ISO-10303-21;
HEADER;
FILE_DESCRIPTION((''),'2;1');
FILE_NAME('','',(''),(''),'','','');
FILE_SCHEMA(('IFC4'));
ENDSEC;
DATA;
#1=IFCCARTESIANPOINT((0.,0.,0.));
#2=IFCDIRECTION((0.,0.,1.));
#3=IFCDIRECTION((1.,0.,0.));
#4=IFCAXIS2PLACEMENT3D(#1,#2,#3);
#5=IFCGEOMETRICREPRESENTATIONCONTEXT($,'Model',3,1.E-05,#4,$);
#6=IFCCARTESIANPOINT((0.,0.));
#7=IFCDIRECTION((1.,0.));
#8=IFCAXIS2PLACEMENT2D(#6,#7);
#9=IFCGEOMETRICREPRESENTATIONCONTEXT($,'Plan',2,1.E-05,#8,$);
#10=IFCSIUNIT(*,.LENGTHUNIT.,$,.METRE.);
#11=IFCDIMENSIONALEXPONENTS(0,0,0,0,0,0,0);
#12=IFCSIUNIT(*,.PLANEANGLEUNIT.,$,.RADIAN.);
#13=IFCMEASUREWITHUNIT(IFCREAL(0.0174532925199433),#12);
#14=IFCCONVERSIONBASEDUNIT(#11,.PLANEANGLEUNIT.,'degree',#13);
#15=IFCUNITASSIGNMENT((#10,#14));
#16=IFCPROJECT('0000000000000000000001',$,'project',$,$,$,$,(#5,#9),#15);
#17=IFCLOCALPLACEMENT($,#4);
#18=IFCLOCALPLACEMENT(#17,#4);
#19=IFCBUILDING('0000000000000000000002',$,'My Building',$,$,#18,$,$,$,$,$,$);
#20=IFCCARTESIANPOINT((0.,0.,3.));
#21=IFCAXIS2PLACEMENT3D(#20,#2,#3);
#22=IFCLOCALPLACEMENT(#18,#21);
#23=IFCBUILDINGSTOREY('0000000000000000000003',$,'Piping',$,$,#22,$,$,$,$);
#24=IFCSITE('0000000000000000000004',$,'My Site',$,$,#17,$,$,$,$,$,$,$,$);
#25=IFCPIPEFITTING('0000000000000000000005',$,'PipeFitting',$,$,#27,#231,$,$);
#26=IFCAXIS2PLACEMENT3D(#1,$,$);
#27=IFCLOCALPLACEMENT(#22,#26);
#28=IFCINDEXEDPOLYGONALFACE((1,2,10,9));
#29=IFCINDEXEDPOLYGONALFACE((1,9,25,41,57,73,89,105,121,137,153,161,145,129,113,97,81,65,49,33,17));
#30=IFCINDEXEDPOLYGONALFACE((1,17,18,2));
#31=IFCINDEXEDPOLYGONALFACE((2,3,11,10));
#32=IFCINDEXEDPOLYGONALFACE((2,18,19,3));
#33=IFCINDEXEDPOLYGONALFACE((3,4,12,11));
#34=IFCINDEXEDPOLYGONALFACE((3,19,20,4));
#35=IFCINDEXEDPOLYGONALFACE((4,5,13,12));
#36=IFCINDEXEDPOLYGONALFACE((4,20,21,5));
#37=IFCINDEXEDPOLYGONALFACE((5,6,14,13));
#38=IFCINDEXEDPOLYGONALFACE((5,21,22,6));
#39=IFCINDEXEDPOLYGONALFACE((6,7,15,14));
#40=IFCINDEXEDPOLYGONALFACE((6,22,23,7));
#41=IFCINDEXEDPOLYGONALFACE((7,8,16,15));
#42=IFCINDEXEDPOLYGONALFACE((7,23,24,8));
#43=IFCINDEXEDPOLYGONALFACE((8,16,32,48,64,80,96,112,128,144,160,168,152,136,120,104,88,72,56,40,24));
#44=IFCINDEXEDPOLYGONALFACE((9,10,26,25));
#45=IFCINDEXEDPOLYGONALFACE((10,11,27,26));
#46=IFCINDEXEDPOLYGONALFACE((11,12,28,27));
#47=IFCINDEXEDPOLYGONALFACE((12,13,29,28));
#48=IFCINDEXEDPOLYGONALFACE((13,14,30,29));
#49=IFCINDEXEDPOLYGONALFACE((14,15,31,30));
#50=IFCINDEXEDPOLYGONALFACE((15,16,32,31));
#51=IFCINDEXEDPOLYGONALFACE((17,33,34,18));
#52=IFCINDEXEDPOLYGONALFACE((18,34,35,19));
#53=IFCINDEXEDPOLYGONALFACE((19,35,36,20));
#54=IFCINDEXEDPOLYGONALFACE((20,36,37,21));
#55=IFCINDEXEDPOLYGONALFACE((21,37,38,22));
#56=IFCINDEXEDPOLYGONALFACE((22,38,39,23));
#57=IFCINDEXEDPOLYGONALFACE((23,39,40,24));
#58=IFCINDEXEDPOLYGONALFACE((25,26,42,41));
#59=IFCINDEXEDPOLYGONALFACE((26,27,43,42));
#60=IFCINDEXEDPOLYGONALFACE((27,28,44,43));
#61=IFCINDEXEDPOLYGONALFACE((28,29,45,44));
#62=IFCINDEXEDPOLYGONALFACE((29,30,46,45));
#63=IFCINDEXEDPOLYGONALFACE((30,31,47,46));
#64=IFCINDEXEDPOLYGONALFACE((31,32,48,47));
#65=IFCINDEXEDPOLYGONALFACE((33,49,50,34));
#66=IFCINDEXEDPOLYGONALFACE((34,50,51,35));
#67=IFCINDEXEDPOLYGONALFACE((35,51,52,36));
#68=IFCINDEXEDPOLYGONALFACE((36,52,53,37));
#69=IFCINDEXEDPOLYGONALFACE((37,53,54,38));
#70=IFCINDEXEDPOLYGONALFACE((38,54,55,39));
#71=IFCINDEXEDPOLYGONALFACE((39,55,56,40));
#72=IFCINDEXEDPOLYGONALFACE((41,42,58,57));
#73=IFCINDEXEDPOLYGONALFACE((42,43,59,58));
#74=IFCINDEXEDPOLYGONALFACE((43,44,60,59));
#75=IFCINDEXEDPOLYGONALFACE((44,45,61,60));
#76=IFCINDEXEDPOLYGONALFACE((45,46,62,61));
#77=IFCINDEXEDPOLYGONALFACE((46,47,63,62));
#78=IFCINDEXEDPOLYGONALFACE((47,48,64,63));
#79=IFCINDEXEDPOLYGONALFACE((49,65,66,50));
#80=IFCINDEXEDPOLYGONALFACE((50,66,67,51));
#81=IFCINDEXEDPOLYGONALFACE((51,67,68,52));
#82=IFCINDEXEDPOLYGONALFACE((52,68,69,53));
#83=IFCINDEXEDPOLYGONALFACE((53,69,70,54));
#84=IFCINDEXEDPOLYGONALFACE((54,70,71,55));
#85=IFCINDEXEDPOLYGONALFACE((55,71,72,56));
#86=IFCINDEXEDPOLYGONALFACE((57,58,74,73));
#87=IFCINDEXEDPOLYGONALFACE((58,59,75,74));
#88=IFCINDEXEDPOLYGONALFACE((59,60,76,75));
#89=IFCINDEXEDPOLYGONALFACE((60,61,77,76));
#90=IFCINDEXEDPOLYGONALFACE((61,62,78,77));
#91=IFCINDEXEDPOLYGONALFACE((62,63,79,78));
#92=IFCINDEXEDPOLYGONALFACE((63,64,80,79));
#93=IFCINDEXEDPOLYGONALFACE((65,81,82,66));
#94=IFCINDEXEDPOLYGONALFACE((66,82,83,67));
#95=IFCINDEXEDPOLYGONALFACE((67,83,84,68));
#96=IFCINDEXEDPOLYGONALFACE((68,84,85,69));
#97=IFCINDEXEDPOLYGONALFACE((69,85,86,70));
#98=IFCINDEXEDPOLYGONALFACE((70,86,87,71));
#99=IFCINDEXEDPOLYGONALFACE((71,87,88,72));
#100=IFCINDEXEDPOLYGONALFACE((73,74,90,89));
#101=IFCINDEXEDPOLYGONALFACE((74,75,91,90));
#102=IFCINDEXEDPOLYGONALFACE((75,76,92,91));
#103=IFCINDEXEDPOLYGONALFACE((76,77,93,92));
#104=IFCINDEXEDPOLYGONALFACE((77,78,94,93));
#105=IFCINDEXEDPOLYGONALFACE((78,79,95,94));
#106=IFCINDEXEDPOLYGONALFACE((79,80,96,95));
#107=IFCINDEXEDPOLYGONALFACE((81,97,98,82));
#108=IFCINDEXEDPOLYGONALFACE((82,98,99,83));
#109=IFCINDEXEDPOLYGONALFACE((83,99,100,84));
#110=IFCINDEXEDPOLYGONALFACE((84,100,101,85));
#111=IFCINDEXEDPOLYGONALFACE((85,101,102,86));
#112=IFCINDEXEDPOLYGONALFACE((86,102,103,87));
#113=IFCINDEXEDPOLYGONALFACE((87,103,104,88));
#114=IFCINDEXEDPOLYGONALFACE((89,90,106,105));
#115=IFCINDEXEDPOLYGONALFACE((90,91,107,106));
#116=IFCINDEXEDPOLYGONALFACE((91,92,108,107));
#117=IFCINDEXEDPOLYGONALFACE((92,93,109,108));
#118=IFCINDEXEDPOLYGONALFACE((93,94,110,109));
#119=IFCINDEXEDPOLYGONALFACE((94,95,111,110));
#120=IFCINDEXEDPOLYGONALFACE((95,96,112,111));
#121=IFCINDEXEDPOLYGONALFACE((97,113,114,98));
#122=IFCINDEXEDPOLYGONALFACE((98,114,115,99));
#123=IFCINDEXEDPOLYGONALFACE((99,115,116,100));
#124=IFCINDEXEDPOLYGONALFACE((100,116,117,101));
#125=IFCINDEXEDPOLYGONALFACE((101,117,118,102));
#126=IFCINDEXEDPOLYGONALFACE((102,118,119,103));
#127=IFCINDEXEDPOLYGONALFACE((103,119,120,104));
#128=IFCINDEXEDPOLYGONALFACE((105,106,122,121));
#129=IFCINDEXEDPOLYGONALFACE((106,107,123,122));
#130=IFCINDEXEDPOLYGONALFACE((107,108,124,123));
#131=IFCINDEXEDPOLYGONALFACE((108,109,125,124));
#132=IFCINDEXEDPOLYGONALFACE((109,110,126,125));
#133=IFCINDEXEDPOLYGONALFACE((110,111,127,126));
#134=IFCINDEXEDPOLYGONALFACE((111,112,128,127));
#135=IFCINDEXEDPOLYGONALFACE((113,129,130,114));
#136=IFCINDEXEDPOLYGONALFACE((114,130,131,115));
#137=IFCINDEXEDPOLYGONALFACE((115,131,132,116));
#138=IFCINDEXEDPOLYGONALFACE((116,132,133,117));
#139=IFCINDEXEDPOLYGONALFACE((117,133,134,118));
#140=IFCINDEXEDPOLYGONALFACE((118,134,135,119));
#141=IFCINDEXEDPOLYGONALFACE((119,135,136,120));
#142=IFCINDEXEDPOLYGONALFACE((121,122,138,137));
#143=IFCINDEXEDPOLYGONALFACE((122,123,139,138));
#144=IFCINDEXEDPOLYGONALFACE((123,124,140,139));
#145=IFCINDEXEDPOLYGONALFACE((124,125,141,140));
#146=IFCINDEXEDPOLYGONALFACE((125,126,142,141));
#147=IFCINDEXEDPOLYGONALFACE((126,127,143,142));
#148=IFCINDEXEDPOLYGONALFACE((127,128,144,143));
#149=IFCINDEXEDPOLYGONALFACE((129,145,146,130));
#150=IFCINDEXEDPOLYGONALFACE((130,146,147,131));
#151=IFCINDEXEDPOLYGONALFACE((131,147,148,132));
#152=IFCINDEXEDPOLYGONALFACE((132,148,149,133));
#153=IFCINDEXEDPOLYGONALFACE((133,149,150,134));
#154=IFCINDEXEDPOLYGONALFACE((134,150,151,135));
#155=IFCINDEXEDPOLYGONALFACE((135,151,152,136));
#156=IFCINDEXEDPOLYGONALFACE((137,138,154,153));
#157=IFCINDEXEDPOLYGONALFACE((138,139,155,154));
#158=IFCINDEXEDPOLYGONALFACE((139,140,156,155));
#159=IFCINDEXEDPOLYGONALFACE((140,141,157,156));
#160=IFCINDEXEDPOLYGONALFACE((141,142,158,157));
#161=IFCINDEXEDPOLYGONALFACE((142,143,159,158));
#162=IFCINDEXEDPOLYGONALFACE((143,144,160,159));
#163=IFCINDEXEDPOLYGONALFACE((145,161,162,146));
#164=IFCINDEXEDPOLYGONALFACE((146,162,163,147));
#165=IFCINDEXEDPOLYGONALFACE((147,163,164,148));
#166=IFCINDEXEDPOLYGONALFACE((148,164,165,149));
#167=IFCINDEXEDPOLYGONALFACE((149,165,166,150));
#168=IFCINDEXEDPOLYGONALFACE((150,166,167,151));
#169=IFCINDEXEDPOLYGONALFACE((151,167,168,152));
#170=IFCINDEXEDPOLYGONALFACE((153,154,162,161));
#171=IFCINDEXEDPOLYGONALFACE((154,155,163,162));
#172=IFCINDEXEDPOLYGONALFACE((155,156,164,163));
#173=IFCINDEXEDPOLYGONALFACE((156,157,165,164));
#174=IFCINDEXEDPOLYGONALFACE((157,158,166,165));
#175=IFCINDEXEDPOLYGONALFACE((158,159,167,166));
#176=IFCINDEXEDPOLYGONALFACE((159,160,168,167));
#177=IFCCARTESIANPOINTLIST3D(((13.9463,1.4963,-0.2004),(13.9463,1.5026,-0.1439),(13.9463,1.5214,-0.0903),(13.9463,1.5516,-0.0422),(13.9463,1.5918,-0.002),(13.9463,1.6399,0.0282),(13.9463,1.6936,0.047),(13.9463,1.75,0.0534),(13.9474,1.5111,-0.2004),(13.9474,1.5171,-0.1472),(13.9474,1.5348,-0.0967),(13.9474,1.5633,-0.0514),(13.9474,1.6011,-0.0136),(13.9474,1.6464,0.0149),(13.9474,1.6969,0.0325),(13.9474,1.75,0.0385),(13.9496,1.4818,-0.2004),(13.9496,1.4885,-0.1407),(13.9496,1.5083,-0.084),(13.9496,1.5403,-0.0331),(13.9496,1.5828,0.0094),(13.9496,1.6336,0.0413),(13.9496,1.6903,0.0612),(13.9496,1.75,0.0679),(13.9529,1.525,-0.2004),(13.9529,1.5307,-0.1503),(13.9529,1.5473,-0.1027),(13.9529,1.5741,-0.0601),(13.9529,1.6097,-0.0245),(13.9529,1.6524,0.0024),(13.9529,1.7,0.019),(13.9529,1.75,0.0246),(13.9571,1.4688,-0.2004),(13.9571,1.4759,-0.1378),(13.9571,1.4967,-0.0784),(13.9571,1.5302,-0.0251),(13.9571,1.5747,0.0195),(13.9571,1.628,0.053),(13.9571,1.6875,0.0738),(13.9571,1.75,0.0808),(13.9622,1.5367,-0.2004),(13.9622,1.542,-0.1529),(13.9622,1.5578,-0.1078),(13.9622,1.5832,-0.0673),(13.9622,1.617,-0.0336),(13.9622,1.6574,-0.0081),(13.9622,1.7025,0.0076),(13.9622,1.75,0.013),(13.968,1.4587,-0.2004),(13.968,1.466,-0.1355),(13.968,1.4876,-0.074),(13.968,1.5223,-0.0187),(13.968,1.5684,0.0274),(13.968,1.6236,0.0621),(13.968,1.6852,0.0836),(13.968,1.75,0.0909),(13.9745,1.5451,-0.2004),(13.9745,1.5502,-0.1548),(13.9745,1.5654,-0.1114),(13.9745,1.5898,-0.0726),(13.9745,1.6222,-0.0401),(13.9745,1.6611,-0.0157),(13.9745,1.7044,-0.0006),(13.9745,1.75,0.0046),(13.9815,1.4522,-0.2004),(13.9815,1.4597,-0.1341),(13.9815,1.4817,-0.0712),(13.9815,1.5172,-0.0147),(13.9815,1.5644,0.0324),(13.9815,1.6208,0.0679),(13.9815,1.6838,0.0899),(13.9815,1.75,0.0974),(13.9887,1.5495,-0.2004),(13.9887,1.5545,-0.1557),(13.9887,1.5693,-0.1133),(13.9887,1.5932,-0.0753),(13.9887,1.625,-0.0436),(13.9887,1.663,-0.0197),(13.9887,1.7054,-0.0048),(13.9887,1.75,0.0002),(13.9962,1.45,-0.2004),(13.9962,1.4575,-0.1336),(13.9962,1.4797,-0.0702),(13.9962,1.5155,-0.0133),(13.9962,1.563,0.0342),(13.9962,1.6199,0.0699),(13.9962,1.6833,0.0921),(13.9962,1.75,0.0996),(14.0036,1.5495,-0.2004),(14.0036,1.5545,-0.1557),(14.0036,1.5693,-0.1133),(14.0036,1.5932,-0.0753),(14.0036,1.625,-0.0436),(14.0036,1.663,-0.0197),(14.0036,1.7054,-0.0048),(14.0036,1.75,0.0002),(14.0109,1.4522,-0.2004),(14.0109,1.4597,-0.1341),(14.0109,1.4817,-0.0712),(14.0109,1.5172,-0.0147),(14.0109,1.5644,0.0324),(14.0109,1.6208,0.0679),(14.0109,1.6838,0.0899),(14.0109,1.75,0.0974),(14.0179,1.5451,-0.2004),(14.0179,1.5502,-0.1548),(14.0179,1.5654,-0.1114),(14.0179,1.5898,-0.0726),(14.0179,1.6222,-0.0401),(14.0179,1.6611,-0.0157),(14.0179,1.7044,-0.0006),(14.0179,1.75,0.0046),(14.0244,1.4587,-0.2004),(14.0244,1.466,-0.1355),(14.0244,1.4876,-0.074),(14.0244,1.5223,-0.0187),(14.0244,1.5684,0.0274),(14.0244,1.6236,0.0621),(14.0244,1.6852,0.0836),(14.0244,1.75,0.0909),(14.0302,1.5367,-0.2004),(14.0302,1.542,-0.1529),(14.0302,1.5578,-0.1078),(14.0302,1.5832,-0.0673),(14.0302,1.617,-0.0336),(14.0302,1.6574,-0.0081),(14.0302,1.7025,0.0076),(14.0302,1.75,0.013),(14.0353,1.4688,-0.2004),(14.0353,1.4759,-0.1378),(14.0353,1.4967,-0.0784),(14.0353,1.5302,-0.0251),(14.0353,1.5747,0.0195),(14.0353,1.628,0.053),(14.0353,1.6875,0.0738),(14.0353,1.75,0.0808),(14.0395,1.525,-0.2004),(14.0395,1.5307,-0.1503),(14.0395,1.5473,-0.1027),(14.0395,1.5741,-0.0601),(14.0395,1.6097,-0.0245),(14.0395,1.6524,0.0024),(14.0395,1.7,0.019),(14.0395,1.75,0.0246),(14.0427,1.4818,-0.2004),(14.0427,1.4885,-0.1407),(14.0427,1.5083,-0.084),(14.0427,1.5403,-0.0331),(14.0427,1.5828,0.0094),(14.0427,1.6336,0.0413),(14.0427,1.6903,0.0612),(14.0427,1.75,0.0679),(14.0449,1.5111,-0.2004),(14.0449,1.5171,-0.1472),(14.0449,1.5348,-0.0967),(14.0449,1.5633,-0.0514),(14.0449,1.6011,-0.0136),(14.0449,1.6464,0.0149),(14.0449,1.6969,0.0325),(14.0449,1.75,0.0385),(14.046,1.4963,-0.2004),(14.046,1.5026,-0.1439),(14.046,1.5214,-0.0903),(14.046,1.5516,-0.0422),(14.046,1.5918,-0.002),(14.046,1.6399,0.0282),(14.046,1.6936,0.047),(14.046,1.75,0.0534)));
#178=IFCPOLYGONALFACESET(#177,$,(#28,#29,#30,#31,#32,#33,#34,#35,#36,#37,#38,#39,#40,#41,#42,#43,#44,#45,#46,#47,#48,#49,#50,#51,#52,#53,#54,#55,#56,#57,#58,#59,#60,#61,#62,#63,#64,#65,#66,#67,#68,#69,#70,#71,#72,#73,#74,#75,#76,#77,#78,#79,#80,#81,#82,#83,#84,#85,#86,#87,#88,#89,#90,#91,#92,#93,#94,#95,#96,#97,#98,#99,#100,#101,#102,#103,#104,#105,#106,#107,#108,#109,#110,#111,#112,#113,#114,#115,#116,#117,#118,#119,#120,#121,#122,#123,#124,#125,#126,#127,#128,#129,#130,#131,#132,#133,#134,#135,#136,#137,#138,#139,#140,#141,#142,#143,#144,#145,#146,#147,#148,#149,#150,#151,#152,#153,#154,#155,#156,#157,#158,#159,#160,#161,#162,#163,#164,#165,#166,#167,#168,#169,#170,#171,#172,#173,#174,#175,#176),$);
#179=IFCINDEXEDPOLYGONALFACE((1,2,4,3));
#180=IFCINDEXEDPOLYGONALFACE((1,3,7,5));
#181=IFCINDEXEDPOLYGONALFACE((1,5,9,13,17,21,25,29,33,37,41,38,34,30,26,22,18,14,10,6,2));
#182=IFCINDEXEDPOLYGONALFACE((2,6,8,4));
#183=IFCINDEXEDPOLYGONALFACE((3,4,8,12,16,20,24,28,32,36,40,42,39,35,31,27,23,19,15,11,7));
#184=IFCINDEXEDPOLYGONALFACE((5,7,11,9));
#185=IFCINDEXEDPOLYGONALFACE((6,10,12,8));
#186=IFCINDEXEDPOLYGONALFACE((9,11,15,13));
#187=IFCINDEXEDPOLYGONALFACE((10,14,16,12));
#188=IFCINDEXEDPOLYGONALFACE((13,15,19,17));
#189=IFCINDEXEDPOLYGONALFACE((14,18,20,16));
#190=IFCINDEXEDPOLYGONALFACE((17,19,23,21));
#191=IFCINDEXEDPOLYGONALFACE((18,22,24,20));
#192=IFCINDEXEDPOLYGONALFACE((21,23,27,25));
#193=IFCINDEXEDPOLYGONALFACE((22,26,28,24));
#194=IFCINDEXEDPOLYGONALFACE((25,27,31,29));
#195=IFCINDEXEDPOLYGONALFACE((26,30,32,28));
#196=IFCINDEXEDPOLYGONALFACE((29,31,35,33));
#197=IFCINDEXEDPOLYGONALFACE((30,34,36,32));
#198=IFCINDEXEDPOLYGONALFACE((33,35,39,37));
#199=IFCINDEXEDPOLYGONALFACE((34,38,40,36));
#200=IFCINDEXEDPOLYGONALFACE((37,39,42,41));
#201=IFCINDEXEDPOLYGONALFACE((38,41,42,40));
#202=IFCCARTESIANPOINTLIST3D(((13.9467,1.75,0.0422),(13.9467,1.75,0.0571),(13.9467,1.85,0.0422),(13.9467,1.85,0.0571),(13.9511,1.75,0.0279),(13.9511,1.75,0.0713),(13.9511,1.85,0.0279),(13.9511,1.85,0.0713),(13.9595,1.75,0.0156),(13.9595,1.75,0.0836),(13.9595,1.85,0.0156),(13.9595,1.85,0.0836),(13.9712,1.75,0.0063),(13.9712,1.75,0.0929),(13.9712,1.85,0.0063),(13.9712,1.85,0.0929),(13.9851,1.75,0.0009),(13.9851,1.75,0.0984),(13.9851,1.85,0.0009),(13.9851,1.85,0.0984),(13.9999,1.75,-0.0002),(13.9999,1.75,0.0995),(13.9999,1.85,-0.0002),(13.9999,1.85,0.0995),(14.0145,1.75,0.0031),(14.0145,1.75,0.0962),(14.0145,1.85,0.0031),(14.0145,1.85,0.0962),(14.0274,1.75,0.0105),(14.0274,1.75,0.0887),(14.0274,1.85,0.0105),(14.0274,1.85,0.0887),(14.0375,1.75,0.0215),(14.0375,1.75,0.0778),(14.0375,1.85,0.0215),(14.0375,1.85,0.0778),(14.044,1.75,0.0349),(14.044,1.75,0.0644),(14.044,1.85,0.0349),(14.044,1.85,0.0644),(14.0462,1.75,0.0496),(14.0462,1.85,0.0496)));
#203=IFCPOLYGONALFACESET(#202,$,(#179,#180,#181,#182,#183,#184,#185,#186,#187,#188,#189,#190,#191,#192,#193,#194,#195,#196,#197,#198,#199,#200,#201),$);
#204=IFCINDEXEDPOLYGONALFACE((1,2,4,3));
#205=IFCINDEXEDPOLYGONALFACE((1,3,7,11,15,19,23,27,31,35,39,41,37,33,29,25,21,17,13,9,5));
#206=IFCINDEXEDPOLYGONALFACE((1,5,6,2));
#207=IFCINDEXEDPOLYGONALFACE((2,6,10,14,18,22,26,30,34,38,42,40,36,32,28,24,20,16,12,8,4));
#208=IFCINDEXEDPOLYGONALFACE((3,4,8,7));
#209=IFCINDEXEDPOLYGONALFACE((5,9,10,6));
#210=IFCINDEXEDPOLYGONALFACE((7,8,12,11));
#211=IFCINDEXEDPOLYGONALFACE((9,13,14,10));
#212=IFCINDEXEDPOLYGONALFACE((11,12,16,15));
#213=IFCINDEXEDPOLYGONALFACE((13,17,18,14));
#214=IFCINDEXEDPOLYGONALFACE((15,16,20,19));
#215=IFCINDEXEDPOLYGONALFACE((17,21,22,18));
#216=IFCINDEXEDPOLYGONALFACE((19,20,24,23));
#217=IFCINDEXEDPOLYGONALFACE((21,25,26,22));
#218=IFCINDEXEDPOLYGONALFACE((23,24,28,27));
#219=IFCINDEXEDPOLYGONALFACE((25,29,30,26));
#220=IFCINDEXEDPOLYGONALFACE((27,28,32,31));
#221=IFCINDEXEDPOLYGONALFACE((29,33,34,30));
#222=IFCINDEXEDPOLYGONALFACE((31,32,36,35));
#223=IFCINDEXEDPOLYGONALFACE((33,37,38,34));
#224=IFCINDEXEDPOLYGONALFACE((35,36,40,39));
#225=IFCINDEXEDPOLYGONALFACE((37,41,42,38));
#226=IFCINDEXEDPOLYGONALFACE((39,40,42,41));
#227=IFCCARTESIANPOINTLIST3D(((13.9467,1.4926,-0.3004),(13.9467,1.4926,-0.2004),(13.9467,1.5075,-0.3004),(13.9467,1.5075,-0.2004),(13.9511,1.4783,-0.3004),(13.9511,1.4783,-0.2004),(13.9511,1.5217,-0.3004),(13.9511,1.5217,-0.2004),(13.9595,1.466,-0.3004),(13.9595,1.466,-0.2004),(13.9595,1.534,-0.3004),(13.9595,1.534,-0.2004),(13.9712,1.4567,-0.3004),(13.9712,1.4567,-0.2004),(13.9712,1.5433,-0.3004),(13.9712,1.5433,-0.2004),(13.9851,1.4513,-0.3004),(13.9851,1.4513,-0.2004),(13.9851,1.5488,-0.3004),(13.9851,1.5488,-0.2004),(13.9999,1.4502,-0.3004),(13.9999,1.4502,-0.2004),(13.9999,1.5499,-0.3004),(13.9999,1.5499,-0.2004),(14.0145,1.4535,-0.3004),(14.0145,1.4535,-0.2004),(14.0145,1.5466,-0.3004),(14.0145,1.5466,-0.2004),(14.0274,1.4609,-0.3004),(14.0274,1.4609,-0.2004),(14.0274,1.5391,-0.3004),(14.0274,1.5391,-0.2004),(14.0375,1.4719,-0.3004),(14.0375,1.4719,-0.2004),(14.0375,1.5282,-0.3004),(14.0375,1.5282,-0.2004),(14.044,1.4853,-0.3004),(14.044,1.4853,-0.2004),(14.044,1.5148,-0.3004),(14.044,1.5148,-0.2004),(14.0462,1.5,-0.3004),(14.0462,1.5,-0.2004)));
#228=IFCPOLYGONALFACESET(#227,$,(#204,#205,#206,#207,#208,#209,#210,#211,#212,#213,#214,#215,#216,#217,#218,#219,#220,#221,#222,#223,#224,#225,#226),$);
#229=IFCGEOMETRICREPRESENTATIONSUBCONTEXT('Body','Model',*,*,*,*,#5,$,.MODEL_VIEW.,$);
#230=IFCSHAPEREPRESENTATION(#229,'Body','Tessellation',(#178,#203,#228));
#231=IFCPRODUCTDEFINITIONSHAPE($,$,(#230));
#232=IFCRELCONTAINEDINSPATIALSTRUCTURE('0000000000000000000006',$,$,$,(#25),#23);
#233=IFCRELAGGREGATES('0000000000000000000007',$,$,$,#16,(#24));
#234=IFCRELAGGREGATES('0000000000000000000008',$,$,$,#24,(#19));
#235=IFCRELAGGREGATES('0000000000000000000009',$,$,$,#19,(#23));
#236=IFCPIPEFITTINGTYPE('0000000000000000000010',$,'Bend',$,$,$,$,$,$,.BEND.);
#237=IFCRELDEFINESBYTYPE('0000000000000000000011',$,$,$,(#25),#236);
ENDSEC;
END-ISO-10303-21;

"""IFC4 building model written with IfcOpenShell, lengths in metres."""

from ifc_helpers import new_model, entity, si_unit, converted_unit, frame, origin_with_axes, origin_2d_with_axis, place, context, subcontext, project, spatial, circle, extrude, source, transform, mapped, type_object, type_shapes, element, save


model = new_model("IFC4")

# Units and contexts
model_context = context("Model", 3, precision=1e-05, world=origin_with_axes())
plan_context = context("Plan", 2, precision=1e-05, world=origin_2d_with_axis())
body_context = subcontext(model_context, "Body", "Model", "MODEL_VIEW")
ifc_project = project(units=[si_unit("LENGTHUNIT", "METRE"), converted_unit("PLANEANGLEUNIT", "degree", entity("IfcReal", 0.0174532925199433), si_unit("PLANEANGLEUNIT", "RADIAN"), dimensions=[0, 0, 0, 0, 0, 0, 0])], contexts=[model_context, plan_context])

# Site, building, storey
site_placement = place(None, origin_with_axes())
site = spatial("IfcSite", under=ifc_project, at=site_placement, Name="My Site")
building_placement = place(site_placement, origin_with_axes())
building = spatial("IfcBuilding", under=site, at=building_placement, Name="My Building")
storey_placement = place(building_placement, frame((0.0, 0.0, 3.0), z_axis=(0.0, 0.0, 1.0), x_axis=(1.0, 0.0, 0.0)))
storey = spatial("IfcBuildingStorey", under=building, at=storey_placement, Name="Piping")

# Pipe fitting
pipe_fitting_type_1 = type_object("IfcPipeFittingType", Name="Bend", PredefinedType="BEND")
shared_shape = source(origin_with_axes(), body_context, "Body", "SolidModel", [
    entity("IfcSweptDiskSolid", entity("IfcIndexedPolyCurve", entity("IfcCartesianPointList3D", [[0.0, 0.0, 0.1], [0.0, -0.0732, 0.2768], [0.0, -0.25, 0.35]]), [entity("IfcArcIndex", [1, 2, 3])]), 0.05),
    extrude(circle(Radius=0.05), origin_with_axes(), (0.0, 0.0, 1.0), 0.1),
    extrude(circle(Radius=0.05), frame((0.0, -0.25, 0.35), z_axis=(0.0, -1.0, 0.0), x_axis=(1.0, 0.0, 0.0)), (0.0, 0.0, 1.0), 0.1),
])
type_shapes(pipe_fitting_type_1, [shared_shape])
for number, where, z_axis, x_axis, name in (
    (1, (13.9962, 1.85, 0.0496), (0.0, -1.0, 0.0), (1.0, 0.0, 0.0), "PipeFitting"),
):
    element("IfcPipeFitting", number, at=place(storey_placement, frame(where, z_axis=z_axis, x_axis=x_axis)), inside=storey, type_object=pipe_fitting_type_1, Name=name, context=body_context, shape_type="MappedRepresentation", body=[
        mapped(shared_shape, transform((0.0, 0.0, 0.0), x_axis=(1.0, 0.0, 0.0), y_axis=(0.0, 1.0, 0.0), z_axis=(0.0, 0.0, 1.0), scale=1.0)),
    ])

save(model, "model.ifc")
